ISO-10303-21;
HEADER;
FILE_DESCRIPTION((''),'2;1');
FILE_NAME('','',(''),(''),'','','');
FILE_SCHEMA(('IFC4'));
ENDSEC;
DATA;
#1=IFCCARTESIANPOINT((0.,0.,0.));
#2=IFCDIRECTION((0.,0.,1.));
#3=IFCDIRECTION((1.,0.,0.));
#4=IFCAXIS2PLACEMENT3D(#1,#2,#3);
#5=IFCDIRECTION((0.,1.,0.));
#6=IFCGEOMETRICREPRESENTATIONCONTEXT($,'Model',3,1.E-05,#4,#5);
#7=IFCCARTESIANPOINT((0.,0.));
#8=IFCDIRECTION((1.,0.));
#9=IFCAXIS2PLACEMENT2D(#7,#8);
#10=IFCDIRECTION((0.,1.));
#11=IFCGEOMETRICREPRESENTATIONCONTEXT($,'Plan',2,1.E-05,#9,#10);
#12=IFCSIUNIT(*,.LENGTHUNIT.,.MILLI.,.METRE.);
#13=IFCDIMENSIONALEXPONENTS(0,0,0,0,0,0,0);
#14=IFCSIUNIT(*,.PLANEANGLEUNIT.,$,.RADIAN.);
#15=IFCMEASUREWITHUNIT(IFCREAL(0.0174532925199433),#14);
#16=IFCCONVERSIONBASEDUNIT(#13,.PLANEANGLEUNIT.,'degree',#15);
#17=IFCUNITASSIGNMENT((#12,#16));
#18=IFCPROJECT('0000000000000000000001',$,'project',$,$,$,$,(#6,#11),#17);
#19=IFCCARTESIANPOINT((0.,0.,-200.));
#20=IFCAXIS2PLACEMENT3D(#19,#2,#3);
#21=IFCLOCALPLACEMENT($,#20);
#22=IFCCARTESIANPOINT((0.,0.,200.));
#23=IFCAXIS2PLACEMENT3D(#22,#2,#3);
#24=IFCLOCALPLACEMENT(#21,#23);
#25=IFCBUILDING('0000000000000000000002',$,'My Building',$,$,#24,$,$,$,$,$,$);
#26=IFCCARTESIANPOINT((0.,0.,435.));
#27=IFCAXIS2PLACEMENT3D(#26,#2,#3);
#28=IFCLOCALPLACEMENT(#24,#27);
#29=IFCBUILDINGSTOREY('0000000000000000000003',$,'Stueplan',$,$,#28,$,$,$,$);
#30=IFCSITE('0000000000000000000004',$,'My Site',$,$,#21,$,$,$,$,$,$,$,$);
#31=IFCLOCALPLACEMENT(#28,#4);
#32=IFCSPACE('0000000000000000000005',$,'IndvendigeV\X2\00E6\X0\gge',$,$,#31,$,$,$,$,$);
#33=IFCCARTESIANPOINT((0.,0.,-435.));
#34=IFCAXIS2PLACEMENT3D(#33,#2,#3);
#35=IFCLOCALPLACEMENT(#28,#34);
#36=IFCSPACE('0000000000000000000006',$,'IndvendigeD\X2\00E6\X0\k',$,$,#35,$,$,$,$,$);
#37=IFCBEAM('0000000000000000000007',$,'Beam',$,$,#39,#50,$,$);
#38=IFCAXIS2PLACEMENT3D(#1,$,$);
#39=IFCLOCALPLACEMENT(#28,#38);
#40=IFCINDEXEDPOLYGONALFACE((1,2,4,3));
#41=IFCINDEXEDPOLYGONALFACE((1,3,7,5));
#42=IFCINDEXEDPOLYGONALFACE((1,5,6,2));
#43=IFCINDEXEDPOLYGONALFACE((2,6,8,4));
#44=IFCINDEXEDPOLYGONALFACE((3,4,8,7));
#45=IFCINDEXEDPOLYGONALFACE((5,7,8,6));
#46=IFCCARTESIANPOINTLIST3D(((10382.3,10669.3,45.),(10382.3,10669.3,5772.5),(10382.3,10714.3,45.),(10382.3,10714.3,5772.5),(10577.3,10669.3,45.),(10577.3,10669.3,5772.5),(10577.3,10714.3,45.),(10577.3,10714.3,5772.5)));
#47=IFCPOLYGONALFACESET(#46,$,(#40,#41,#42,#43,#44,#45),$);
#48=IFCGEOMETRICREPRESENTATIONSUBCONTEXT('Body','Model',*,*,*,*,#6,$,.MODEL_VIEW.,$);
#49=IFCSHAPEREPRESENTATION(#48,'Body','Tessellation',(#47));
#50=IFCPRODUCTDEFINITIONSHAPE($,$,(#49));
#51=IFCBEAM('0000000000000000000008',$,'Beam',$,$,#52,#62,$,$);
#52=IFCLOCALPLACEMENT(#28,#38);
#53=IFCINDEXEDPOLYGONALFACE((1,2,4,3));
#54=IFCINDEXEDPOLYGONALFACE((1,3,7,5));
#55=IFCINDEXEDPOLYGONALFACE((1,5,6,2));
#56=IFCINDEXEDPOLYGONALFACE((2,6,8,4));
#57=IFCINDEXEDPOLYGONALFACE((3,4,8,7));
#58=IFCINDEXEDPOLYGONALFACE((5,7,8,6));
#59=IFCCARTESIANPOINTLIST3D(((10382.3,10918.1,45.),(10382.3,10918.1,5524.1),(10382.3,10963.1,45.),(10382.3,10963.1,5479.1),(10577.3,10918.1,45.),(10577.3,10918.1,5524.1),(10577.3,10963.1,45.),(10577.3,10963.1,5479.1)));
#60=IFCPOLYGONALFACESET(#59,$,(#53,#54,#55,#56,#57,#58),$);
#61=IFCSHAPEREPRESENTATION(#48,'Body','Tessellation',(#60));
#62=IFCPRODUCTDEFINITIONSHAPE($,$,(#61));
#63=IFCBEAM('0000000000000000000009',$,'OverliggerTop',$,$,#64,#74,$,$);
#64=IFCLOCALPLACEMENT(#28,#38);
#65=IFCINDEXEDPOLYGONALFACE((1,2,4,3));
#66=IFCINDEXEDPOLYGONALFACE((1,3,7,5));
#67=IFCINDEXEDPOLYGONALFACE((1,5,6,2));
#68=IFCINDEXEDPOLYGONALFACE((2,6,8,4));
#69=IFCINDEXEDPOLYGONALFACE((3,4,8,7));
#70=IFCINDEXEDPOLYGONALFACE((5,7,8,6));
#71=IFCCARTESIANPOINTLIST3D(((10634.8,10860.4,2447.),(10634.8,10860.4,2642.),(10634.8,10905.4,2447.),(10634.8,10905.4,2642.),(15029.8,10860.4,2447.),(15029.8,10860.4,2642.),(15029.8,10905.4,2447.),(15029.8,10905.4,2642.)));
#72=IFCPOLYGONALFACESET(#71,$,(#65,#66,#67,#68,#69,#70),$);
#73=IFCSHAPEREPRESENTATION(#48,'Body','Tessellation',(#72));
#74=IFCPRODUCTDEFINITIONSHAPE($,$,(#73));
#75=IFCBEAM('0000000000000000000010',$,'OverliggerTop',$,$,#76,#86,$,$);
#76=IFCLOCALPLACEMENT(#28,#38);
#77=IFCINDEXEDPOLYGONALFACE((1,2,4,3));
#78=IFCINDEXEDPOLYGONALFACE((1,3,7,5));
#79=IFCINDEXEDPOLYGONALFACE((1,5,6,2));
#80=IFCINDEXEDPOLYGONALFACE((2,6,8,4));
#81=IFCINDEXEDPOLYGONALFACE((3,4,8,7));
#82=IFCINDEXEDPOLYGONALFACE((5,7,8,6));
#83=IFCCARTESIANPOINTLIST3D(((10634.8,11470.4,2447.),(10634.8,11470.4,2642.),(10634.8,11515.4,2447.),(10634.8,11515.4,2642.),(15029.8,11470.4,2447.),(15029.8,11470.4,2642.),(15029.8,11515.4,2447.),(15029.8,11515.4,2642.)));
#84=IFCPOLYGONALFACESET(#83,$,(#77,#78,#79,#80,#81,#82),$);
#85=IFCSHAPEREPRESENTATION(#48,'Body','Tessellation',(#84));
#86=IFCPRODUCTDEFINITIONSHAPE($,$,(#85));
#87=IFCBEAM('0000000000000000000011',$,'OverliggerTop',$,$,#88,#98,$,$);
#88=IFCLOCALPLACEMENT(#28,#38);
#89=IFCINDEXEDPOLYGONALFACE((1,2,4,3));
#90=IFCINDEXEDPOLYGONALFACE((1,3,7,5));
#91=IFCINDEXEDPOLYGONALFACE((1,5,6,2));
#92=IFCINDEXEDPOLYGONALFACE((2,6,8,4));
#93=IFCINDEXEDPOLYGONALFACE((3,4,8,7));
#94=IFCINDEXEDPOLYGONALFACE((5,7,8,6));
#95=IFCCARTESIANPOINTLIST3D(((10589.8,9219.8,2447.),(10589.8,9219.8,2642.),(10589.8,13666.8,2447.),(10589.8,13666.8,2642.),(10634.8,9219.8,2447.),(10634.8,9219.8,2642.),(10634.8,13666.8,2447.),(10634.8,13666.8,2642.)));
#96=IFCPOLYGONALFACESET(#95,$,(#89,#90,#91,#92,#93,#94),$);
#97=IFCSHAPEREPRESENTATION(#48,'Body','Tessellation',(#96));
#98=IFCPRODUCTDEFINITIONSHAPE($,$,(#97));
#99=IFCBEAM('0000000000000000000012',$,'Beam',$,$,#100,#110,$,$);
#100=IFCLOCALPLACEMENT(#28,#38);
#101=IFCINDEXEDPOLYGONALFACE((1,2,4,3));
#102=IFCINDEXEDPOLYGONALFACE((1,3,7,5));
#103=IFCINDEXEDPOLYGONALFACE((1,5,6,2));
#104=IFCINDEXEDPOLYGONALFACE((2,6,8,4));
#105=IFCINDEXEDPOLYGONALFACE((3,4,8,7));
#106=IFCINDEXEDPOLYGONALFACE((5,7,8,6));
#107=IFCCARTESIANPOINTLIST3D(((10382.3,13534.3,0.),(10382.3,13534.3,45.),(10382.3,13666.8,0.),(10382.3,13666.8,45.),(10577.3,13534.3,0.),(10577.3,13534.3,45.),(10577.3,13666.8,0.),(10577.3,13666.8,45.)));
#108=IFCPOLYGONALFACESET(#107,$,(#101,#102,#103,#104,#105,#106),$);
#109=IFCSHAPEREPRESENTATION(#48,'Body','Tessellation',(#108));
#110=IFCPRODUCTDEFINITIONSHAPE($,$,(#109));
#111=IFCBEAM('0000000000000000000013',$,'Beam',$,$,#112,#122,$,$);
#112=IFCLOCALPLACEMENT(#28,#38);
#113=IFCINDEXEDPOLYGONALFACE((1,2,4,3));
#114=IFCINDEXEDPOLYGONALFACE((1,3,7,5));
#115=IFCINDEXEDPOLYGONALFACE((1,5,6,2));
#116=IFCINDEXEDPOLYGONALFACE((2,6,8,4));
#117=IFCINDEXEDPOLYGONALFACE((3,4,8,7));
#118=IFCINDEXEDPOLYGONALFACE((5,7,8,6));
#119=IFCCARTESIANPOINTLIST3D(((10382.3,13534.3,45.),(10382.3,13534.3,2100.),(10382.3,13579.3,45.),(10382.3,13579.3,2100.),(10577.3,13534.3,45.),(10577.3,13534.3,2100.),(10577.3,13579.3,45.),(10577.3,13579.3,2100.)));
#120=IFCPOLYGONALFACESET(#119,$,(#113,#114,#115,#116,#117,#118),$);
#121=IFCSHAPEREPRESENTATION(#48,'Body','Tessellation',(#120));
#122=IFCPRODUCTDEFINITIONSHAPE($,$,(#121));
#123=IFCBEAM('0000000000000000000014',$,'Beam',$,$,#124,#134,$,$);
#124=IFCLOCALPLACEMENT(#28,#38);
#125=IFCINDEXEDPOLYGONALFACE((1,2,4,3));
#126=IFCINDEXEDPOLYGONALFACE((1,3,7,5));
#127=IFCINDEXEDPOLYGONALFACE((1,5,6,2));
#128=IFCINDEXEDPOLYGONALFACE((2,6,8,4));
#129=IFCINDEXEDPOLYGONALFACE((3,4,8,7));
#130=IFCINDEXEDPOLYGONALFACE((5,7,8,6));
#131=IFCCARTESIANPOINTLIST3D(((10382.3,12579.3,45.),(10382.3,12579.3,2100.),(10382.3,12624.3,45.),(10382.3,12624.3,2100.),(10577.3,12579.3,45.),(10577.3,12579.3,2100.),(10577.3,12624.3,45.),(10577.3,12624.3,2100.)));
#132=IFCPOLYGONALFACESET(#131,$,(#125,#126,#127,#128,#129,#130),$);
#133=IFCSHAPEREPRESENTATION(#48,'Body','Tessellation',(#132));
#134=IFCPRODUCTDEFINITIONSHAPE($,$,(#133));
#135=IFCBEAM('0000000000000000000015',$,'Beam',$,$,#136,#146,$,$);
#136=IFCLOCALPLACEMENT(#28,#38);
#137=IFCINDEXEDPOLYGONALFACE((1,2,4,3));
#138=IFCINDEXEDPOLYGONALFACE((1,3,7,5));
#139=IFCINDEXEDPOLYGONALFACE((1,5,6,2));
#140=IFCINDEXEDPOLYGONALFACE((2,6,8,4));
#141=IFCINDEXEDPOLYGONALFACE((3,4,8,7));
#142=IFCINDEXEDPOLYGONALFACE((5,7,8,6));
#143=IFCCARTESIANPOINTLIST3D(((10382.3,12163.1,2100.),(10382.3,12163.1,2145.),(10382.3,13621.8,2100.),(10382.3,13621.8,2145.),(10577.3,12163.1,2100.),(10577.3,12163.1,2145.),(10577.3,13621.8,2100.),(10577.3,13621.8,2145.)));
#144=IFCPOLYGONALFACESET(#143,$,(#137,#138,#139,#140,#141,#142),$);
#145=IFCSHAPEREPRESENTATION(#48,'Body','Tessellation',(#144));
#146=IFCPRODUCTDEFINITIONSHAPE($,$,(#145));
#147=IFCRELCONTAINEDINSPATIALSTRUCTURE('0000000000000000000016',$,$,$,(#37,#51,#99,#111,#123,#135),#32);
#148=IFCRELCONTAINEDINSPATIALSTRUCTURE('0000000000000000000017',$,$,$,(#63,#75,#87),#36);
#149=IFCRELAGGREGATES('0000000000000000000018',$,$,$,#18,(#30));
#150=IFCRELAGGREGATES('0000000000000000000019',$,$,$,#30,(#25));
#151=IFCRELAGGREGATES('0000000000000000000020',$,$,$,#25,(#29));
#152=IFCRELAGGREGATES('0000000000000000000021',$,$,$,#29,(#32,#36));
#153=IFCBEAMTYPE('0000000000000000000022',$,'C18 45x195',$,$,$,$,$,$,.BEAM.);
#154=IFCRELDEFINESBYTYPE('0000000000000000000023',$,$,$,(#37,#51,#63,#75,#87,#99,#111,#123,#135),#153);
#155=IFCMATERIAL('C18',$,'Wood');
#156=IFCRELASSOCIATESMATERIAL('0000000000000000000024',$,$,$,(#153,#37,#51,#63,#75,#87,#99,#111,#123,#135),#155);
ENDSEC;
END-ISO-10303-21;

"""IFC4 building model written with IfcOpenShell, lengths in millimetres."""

from ifc_helpers import new_model, entity, si_unit, converted_unit, direction, frame, origin_with_axes, origin_2d_with_axis, place, context, subcontext, project, spatial, rectangle, extrude, clip, halfspace, material, material_profile, profile_set, profile_usage, type_object, element, save


model = new_model("IFC4")

# Units and contexts
model_context = context("Model", 3, precision=1e-05, world=origin_with_axes(), true_north=direction((0.0, 1.0, 0.0)))
plan_context = context("Plan", 2, precision=1e-05, world=origin_2d_with_axis(), true_north=direction((0.0, 1.0)))
body_context_1 = subcontext(model_context, "Body", "Model", "MODEL_VIEW")
ifc_project = project(units=[si_unit("LENGTHUNIT", "METRE", prefix="MILLI"), converted_unit("PLANEANGLEUNIT", "degree", entity("IfcReal", 0.0174532925199433), si_unit("PLANEANGLEUNIT", "RADIAN"), dimensions=[0, 0, 0, 0, 0, 0, 0])], contexts=[model_context, plan_context])

# Site, building, storey
site_placement = place(None, frame((0.0, 0.0, -200.0), z_axis=(0.0, 0.0, 1.0), x_axis=(1.0, 0.0, 0.0)))
site = spatial("IfcSite", under=ifc_project, at=site_placement, Name="My Site")
building_placement = place(site_placement, frame((0.0, 0.0, 200.0), z_axis=(0.0, 0.0, 1.0), x_axis=(1.0, 0.0, 0.0)))
building = spatial("IfcBuilding", under=site, at=building_placement, Name="My Building")
storey_placement = place(building_placement, frame((0.0, 0.0, 435.0), z_axis=(0.0, 0.0, 1.0), x_axis=(1.0, 0.0, 0.0)))
storey = spatial("IfcBuildingStorey", under=building, at=storey_placement, Name="Stueplan")

# Shared definitions
ifc_material = material(Name="C18", Category="Wood")

# Shared definitions
space_1_placement = place(storey_placement, frame((0.0, 0.0, 0.0), z_axis=(0.0, 0.0, 1.0), x_axis=(1.0, 0.0, 0.0)))
space_1 = spatial("IfcSpace", under=storey, at=space_1_placement, Name="IndvendigeVægge")

# Beams
ifc_material_profile_1 = material_profile(ifc_material, rectangle(XDim=45.0, YDim=195.0))
ifc_profile_set_1 = profile_set([ifc_material_profile_1], Name="woodStructural")
beam_type_1 = type_object("IfcBeamType", Name="C18 45x195", PredefinedType="BEAM", material=ifc_profile_set_1)
ifc_profile_usage_1 = profile_usage(ifc_profile_set_1)
beam_1_placement = place(space_1_placement, frame((10479.8, 10691.8, 45.0), z_axis=(0.0, 0.0, 1.0), x_axis=(0.0, 1.0, 0.0)))
element("IfcBeam", 1, at=beam_1_placement, inside=space_1, type_object=beam_type_1, material=ifc_profile_usage_1, Name="Beam", context=body_context_1, shape_type="SweptSolid", body=[
    extrude(rectangle(XDim=45.0, YDim=195.0), origin_with_axes(), (0.0, 0.0, 1.0), 5727.5),
])
ifc_profile_usage_2 = profile_usage(ifc_profile_set_1)
beam_2_placement = place(space_1_placement, frame((10479.8, 10940.6, 45.0), z_axis=(0.0, 0.0, 1.0), x_axis=(0.0, 1.0, 0.0)))
element("IfcBeam", 2, at=beam_2_placement, inside=space_1, type_object=beam_type_1, material=ifc_profile_usage_2, Name="Beam", context=body_context_1, shape_type="Clipping", body=[
    clip(extrude(rectangle(XDim=45.0, YDim=195.0), origin_with_axes(), (0.0, 0.0, 1.0), 5651.6), halfspace(frame((2848.2, 0.0, 2608.4), z_axis=(0.707107, 0.0, 0.707107), x_axis=(0.0, -1.0, 0.0)), False)),
])

# Shared definitions
space_2_placement = place(storey_placement, frame((0.0, 0.0, -435.0), z_axis=(0.0, 0.0, 1.0), x_axis=(1.0, 0.0, 0.0)))
space_2 = spatial("IfcSpace", under=storey, at=space_2_placement, Name="IndvendigeDæk")

# Beams
ifc_profile_usage_3 = profile_usage(ifc_profile_set_1)
beam_3_placement = place(space_2_placement, frame((10634.8, 10882.9, 2979.5), z_axis=(1.0, 0.000001, 0.0), x_axis=(0.000001, -1.0, 0.0)))
element("IfcBeam", 3, at=beam_3_placement, inside=space_2, type_object=beam_type_1, material=ifc_profile_usage_3, Name="OverliggerTop", context=body_context_1, shape_type="SweptSolid", body=[
    extrude(rectangle(XDim=45.0, YDim=195.0), origin_with_axes(), (0.0, 0.0, 1.0), 4395.0),
])
ifc_profile_usage_4 = profile_usage(ifc_profile_set_1)
beam_4_placement = place(space_2_placement, frame((10634.8, 11492.9, 2979.5), z_axis=(1.0, 0.000001, 0.0), x_axis=(0.000001, -1.0, 0.0)))
element("IfcBeam", 4, at=beam_4_placement, inside=space_2, type_object=beam_type_1, material=ifc_profile_usage_4, Name="OverliggerTop", context=body_context_1, shape_type="SweptSolid", body=[
    extrude(rectangle(XDim=45.0, YDim=195.0), origin_with_axes(), (0.0, 0.0, 1.0), 4395.0),
])
ifc_profile_usage_5 = profile_usage(ifc_profile_set_1)
beam_5_placement = place(space_2_placement, frame((10612.3, 13666.8, 2979.5), z_axis=(0.000001, -1.0, 0.0), x_axis=(-1.0, -0.000001, 0.0)))
element("IfcBeam", 5, at=beam_5_placement, inside=space_2, type_object=beam_type_1, material=ifc_profile_usage_5, Name="OverliggerTop", context=body_context_1, shape_type="SweptSolid", body=[
    extrude(rectangle(XDim=45.0, YDim=195.0), origin_with_axes(), (0.0, 0.0, 1.0), 4447.0),
])
ifc_profile_usage_6 = profile_usage(ifc_profile_set_1)
beam_6_placement = place(space_1_placement, frame((10479.8, 13534.3, 22.5), z_axis=(0.0, 1.0, 0.0), x_axis=(0.0, 0.0, 1.0)))
element("IfcBeam", 6, at=beam_6_placement, inside=space_1, type_object=beam_type_1, material=ifc_profile_usage_6, Name="Beam", context=body_context_1, shape_type="SweptSolid", body=[
    extrude(rectangle(XDim=45.0, YDim=195.0), origin_with_axes(), (0.0, 0.0, 1.0), 132.5),
])
ifc_profile_usage_7 = profile_usage(ifc_profile_set_1)
beam_7_placement = place(space_1_placement, frame((10479.8, 13556.8, 45.0), z_axis=(0.0, 0.0, 1.0), x_axis=(0.0, 1.0, 0.0)))
element("IfcBeam", 7, at=beam_7_placement, inside=space_1, type_object=beam_type_1, material=ifc_profile_usage_7, Name="Beam", context=body_context_1, shape_type="SweptSolid", body=[
    extrude(rectangle(XDim=45.0, YDim=195.0), origin_with_axes(), (0.0, 0.0, 1.0), 2055.0),
])
ifc_profile_usage_8 = profile_usage(ifc_profile_set_1)
beam_8_placement = place(space_1_placement, frame((10479.8, 12601.8, 45.0), z_axis=(0.0, 0.0, 1.0), x_axis=(0.0, 1.0, 0.0)))
element("IfcBeam", 8, at=beam_8_placement, inside=space_1, type_object=beam_type_1, material=ifc_profile_usage_8, Name="Beam", context=body_context_1, shape_type="SweptSolid", body=[
    extrude(rectangle(XDim=45.0, YDim=195.0), origin_with_axes(), (0.0, 0.0, 1.0), 2055.0),
])
ifc_profile_usage_9 = profile_usage(ifc_profile_set_1)
beam_9_placement = place(space_1_placement, frame((10479.8, 12163.1, 2122.5), z_axis=(0.0, 1.0, 0.0), x_axis=(0.0, 0.0, 1.0)))
element("IfcBeam", 9, at=beam_9_placement, inside=space_1, type_object=beam_type_1, material=ifc_profile_usage_9, Name="Beam", context=body_context_1, shape_type="SweptSolid", body=[
    extrude(rectangle(XDim=45.0, YDim=195.0), origin_with_axes(), (0.0, 0.0, 1.0), 1458.7),
])

save(model, "model.ifc")
